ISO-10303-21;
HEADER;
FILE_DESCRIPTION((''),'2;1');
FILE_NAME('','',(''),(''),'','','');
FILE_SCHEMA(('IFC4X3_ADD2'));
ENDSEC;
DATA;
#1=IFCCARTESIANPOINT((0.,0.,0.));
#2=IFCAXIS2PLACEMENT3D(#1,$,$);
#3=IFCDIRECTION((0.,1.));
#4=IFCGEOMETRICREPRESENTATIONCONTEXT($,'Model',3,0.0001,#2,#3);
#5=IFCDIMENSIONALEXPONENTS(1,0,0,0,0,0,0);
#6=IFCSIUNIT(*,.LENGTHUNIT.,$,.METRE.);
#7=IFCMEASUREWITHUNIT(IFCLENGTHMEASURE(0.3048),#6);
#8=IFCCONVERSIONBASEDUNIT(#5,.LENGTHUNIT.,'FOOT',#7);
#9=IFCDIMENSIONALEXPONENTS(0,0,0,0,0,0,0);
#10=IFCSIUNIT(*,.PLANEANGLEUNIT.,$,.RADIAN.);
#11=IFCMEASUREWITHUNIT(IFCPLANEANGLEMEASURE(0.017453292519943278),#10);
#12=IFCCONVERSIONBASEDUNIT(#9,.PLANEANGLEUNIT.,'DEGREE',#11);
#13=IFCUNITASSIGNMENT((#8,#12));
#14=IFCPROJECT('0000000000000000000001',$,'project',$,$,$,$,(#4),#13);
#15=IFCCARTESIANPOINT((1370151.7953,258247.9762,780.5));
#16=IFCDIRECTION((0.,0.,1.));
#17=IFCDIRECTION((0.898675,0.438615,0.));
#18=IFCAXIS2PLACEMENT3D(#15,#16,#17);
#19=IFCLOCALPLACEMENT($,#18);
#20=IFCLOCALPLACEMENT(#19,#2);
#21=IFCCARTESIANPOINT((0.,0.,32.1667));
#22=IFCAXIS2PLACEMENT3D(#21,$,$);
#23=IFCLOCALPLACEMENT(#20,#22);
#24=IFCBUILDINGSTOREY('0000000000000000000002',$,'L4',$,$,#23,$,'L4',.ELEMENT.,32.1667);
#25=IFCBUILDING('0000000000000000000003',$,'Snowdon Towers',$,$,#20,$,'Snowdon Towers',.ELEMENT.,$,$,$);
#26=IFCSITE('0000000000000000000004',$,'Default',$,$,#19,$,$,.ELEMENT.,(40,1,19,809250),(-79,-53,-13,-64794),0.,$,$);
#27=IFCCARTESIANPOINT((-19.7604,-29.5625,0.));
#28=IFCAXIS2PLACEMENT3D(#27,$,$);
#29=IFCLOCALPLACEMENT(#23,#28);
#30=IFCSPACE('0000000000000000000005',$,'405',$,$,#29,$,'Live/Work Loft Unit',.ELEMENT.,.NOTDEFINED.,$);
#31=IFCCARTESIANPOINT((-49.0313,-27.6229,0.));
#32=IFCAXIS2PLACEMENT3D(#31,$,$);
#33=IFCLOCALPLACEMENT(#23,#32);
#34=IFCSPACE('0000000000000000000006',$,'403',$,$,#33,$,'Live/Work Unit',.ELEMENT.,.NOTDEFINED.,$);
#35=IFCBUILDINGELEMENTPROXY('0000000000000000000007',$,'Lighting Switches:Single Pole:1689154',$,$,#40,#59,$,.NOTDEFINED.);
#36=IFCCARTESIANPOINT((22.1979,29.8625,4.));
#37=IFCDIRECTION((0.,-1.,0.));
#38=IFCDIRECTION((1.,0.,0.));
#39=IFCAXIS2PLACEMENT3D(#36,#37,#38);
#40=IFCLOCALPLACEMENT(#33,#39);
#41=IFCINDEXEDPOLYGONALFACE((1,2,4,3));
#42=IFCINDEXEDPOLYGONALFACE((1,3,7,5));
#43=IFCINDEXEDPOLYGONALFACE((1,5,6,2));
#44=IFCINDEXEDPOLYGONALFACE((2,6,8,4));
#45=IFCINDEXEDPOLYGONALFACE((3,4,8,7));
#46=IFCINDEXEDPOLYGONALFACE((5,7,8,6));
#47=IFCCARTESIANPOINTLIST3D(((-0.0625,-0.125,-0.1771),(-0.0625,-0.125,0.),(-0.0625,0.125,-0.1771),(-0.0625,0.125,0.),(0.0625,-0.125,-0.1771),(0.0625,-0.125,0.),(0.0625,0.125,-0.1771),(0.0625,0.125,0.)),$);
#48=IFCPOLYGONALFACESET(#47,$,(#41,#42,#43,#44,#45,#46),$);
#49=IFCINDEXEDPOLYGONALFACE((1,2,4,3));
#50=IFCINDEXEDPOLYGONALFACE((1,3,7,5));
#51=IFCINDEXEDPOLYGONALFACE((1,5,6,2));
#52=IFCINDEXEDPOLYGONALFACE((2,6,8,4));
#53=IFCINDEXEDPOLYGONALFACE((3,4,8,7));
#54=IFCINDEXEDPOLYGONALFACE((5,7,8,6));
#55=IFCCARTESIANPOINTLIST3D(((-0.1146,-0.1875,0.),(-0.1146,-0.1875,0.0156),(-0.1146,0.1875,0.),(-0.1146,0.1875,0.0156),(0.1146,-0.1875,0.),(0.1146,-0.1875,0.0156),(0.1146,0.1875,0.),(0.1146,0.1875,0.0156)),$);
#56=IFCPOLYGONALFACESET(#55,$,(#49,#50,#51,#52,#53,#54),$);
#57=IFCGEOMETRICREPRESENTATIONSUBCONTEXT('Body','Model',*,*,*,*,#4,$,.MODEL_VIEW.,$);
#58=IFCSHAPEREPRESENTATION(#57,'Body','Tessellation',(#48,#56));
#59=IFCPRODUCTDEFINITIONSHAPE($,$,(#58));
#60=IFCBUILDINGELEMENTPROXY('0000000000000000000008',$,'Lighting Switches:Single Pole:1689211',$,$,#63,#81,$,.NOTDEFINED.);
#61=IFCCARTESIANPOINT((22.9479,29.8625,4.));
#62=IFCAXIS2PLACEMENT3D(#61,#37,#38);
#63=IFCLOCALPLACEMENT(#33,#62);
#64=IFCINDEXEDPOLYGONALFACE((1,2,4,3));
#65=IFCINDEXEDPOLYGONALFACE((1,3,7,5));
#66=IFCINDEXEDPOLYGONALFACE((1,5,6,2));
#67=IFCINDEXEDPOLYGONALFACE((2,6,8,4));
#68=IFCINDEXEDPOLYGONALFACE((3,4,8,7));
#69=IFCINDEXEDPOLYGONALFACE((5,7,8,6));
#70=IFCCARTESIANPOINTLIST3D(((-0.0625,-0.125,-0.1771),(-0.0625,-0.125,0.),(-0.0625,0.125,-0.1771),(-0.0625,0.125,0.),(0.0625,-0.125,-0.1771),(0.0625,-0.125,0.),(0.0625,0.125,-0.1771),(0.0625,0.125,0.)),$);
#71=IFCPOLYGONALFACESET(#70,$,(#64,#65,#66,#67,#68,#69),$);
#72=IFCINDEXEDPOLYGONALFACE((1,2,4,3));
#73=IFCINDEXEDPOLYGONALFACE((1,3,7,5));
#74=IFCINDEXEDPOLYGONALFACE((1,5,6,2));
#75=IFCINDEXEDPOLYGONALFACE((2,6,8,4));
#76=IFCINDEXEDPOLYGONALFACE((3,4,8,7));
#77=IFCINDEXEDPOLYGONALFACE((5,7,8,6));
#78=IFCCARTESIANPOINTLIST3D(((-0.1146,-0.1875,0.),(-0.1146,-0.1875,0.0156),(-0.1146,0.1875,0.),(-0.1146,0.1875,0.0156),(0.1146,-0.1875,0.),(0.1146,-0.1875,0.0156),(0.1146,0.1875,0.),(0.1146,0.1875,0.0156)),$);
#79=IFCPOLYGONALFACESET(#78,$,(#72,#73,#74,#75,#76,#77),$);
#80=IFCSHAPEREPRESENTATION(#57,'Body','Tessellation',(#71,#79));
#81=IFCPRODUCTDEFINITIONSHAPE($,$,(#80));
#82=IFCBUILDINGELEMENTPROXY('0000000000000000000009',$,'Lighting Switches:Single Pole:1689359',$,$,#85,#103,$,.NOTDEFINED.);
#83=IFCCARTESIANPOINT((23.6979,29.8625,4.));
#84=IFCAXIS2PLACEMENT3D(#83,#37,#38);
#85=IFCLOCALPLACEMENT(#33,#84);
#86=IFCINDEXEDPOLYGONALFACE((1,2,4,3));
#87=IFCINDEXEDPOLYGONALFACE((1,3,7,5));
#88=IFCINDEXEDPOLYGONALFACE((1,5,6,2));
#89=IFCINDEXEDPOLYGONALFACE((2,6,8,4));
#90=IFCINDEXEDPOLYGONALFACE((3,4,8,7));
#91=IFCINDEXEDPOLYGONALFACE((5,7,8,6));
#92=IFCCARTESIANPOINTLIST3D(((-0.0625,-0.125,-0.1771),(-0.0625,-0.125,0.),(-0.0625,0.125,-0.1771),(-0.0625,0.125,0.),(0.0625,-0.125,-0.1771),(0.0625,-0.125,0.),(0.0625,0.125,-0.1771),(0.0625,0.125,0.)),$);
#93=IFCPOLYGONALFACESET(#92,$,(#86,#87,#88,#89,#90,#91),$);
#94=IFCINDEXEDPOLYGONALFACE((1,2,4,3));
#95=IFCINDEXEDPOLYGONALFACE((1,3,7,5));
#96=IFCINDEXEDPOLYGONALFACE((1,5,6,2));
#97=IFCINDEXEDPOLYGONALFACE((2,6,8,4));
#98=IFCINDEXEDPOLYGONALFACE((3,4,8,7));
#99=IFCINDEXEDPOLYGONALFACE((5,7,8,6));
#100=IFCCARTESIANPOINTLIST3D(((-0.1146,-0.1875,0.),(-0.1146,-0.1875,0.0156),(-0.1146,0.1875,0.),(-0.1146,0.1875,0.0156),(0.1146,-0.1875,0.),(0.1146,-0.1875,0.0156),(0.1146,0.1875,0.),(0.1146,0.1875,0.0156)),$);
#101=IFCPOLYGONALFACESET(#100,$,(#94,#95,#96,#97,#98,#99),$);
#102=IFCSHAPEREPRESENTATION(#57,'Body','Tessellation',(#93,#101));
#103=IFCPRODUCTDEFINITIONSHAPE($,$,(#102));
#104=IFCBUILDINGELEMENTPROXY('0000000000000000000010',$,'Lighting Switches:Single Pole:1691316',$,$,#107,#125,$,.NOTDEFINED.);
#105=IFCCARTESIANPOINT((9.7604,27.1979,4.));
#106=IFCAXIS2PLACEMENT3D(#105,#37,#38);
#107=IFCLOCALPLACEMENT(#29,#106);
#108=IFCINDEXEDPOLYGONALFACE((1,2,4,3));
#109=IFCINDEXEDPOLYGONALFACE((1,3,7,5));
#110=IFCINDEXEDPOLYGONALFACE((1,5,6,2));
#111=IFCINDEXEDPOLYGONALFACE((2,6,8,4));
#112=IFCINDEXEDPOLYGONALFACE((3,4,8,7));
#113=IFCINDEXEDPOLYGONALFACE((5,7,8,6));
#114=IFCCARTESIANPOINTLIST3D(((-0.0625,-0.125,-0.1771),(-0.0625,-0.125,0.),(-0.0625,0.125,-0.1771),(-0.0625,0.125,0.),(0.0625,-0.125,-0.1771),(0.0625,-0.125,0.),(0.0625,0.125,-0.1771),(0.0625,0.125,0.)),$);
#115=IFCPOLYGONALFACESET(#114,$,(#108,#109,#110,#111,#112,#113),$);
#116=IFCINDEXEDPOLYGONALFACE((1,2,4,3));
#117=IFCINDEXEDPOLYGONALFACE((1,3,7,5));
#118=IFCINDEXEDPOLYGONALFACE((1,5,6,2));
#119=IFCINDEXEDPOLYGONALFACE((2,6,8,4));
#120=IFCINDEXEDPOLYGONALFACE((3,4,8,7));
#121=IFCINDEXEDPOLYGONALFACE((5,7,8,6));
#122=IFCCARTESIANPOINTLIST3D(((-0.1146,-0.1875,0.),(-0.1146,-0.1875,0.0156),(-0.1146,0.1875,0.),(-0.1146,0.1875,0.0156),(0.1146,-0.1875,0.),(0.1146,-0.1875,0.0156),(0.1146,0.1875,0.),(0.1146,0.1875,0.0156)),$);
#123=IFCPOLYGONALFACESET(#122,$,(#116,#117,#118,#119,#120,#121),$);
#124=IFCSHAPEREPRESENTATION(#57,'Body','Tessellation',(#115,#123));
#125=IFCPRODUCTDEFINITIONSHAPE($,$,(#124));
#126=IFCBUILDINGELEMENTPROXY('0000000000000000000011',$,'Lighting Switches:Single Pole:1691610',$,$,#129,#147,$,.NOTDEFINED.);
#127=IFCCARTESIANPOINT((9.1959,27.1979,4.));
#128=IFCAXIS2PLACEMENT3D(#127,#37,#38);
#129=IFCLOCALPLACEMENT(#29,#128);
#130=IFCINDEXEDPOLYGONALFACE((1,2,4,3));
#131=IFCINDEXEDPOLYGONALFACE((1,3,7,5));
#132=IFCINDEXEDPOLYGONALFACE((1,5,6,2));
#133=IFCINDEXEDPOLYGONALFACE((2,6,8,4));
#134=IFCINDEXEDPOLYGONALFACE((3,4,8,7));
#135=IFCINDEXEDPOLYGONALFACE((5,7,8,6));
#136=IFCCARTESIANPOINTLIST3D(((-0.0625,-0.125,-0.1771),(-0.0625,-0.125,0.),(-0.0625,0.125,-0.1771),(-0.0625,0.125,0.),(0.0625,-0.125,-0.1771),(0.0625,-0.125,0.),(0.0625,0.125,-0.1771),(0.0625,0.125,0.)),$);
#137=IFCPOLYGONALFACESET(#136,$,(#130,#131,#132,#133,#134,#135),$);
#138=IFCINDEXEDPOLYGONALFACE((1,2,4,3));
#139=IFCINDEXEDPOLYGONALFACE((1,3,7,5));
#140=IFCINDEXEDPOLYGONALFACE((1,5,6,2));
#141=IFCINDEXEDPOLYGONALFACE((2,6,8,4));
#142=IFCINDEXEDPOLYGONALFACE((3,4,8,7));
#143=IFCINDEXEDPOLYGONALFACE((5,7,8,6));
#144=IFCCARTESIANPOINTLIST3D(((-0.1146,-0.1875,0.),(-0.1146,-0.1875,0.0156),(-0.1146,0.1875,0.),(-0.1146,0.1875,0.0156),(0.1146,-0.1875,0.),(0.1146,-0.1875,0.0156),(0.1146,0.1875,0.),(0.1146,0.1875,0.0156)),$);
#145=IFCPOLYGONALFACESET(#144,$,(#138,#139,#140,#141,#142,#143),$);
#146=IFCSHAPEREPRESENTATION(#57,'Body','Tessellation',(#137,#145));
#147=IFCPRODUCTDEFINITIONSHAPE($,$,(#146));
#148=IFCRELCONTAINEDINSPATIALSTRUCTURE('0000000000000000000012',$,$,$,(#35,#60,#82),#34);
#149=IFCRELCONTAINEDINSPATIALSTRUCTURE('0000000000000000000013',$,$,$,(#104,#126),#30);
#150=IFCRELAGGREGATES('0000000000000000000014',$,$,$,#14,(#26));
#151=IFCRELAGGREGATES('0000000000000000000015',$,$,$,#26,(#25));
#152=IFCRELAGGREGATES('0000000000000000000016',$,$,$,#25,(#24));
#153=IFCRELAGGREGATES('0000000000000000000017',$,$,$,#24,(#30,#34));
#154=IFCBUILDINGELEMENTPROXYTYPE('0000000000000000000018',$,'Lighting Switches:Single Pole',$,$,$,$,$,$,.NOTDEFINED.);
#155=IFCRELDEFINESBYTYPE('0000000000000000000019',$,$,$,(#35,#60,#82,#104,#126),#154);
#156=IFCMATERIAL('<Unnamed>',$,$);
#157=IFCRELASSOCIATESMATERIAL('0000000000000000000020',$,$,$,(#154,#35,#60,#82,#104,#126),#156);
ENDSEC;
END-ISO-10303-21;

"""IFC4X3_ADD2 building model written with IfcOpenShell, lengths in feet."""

from ifc_helpers import new_model, entity, si_unit, converted_unit, direction, frame, frame_2d, origin, origin_2d_with_axis, place, context, subcontext, project, spatial, rectangle, extrude, source, transform, mapped, material, type_object, type_shapes, element, save


model = new_model("IFC4X3_ADD2")

# Units and contexts
model_context = context("Model", 3, precision=0.0001, world=origin(), true_north=direction((0.0, 1.0)))
body_context = subcontext(model_context, "Body", "Model", "MODEL_VIEW")
ifc_project = project(units=[converted_unit("LENGTHUNIT", "FOOT", entity("IfcLengthMeasure", 0.3048), si_unit("LENGTHUNIT", "METRE"), dimensions=[1, 0, 0, 0, 0, 0, 0]), converted_unit("PLANEANGLEUNIT", "DEGREE", entity("IfcPlaneAngleMeasure", 0.017453292519943278), si_unit("PLANEANGLEUNIT", "RADIAN"), dimensions=[0, 0, 0, 0, 0, 0, 0])], contexts=[model_context])

# Site, building, storey
site_placement = place(None, frame((1370151.7953, 258247.9762, 780.5), z_axis=(0.0, 0.0, 1.0), x_axis=(0.898675, 0.438615, 0.0)))
site = spatial("IfcSite", under=ifc_project, at=site_placement, Name="Default", CompositionType="ELEMENT", RefLatitude=(40, 1, 19, 809250), RefLongitude=(-79, -53, -13, -64794), RefElevation=0.0)
building_placement = place(site_placement, origin())
building = spatial("IfcBuilding", under=site, at=building_placement, Name="Snowdon Towers", LongName="Snowdon Towers", CompositionType="ELEMENT")
storey_placement = place(building_placement, frame((0.0, 0.0, 32.1667)))
storey = spatial("IfcBuildingStorey", under=building, at=storey_placement, Name="L4", LongName="L4", CompositionType="ELEMENT", Elevation=32.1667)

# Shared definitions
space_1_placement = place(storey_placement, frame((-19.7604, -29.5625, 0.0)))
space_1 = spatial("IfcSpace", under=storey, at=space_1_placement, Name="405", LongName="Live/Work Loft Unit", CompositionType="ELEMENT", PredefinedType="NOTDEFINED")

# Shared definitions
ifc_material_1 = material(Name="<Unnamed>")

# Shared definitions
space_2_placement = place(storey_placement, frame((-49.0313, -27.6229, 0.0)))
space_2 = spatial("IfcSpace", under=storey, at=space_2_placement, Name="403", LongName="Live/Work Unit", CompositionType="ELEMENT", PredefinedType="NOTDEFINED")

# Building element proxies
building_element_proxy_type_1 = type_object("IfcBuildingElementProxyType", Name="Lighting Switches:Single Pole", PredefinedType="NOTDEFINED", material=ifc_material_1)
shared_shape_1 = source(origin(), body_context, "Body", "SweptSolid", [
    extrude(rectangle(XDim=0.125, YDim=0.25, at=origin_2d_with_axis()), frame((0.0, 0.0, -0.1771), z_axis=(0.0, 0.0, 1.0), x_axis=(-1.0, 0.0, 0.0)), (0.0, 0.0, 1.0), 0.1771),
    extrude(rectangle(XDim=0.2292, YDim=0.375, at=frame_2d((0.0, 0.0), x_axis=(1.0, 0.0))), frame((0.0, 0.0, 0.0), z_axis=(0.0, 0.0, 1.0), x_axis=(-1.0, 0.0, 0.0)), (0.0, 0.0, 1.0), 0.0156),
])
type_shapes(building_element_proxy_type_1, [shared_shape_1])
for number, where, z_axis, x_axis, name in (
    (1, (22.1979, 29.8625, 4.0), (0.0, -1.0, 0.0), (1.0, 0.0, 0.0), "Lighting Switches:Single Pole:1689154"),
    (2, (22.9479, 29.8625, 4.0), (0.0, -1.0, 0.0), (1.0, 0.0, 0.0), "Lighting Switches:Single Pole:1689211"),
    (3, (23.6979, 29.8625, 4.0), (0.0, -1.0, 0.0), (1.0, 0.0, 0.0), "Lighting Switches:Single Pole:1689359"),
):
    element("IfcBuildingElementProxy", number, at=place(space_2_placement, frame(where, z_axis=z_axis, x_axis=x_axis)), inside=space_2, type_object=building_element_proxy_type_1, material=ifc_material_1, Name=name, PredefinedType="NOTDEFINED", context=body_context, shape_type="MappedRepresentation", body=[
        mapped(shared_shape_1, transform((0.0, 0.0, 0.0), scale=1.0)),
    ])
for number, where, z_axis, x_axis, name in (
    (4, (9.7604, 27.1979, 4.0), (0.0, -1.0, 0.0), (1.0, 0.0, 0.0), "Lighting Switches:Single Pole:1691316"),
    (5, (9.1959, 27.1979, 4.0), (0.0, -1.0, 0.0), (1.0, 0.0, 0.0), "Lighting Switches:Single Pole:1691610"),
):
    element("IfcBuildingElementProxy", number, at=place(space_1_placement, frame(where, z_axis=z_axis, x_axis=x_axis)), inside=space_1, type_object=building_element_proxy_type_1, material=ifc_material_1, Name=name, PredefinedType="NOTDEFINED", context=body_context, shape_type="MappedRepresentation", body=[
        mapped(shared_shape_1, transform((0.0, 0.0, 0.0), scale=1.0)),
    ])

save(model, "model.ifc")
